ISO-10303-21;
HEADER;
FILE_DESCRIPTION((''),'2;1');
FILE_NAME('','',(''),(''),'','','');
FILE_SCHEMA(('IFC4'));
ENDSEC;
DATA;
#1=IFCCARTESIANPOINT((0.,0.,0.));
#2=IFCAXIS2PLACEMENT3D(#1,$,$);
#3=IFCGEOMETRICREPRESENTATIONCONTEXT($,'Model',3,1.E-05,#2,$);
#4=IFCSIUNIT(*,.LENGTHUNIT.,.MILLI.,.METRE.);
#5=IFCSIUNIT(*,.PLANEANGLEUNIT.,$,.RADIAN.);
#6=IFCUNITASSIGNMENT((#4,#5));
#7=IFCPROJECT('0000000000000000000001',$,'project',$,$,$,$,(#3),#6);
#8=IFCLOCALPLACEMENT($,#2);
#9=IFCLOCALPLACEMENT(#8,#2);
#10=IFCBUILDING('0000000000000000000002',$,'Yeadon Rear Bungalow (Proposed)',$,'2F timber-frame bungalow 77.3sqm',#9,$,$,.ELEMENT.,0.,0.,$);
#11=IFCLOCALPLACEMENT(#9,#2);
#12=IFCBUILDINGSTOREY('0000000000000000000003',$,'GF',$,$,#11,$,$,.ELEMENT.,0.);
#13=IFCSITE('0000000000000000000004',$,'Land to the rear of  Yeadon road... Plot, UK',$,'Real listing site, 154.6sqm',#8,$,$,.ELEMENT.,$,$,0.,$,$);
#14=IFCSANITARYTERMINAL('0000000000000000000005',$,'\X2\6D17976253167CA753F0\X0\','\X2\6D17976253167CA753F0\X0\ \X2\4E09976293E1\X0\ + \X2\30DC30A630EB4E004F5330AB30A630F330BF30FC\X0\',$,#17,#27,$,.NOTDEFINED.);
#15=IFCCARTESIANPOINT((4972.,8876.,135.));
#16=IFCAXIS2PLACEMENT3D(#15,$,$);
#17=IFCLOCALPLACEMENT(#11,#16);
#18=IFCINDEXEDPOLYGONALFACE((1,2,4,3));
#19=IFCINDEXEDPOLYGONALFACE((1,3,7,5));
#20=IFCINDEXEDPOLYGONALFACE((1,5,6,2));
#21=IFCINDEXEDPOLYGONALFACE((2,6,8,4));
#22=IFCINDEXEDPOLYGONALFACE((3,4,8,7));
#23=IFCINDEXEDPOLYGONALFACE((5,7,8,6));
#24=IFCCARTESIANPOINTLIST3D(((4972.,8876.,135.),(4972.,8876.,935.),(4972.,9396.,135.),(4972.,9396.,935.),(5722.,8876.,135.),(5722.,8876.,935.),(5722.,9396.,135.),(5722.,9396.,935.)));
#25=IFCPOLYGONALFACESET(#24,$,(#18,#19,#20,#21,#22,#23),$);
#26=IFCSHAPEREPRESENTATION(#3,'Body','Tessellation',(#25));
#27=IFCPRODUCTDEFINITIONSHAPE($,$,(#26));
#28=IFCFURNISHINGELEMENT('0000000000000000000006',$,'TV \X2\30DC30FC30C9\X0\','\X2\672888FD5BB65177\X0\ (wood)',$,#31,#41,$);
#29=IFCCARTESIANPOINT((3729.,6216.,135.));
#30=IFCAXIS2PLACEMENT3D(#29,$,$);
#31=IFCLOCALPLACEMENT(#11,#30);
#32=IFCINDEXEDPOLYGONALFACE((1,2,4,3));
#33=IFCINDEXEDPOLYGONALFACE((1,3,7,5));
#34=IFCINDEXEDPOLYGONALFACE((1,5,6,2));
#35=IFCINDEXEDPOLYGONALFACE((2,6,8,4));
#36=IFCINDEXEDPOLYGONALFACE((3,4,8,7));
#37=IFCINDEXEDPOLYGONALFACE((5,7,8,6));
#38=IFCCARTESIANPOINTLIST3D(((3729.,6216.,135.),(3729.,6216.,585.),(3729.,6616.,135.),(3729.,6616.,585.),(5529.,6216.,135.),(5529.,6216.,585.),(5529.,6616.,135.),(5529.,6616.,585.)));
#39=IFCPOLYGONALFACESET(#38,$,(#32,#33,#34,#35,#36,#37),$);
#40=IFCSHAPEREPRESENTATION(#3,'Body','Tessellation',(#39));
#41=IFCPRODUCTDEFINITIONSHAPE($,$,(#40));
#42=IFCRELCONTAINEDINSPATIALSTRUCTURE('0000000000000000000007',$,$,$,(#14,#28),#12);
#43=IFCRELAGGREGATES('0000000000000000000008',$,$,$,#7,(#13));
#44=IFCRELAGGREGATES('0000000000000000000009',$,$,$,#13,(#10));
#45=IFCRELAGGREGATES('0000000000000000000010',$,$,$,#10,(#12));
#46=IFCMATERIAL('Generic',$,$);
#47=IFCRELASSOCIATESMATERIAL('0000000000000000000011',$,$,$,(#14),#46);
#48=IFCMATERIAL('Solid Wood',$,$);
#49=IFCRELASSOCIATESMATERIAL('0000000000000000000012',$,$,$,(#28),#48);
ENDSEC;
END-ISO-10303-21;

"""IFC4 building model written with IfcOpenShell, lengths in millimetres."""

from ifc_helpers import new_model, si_unit, frame, frame_2d, origin, place, context, project, spatial, rectangle, extrude, material, element, save


model = new_model("IFC4")

# Units and contexts
model_context = context("Model", 3, precision=1e-05, world=origin())
ifc_project = project(units=[si_unit("LENGTHUNIT", "METRE", prefix="MILLI"), si_unit("PLANEANGLEUNIT", "RADIAN")], contexts=[model_context])

# Site, building, storey
site_placement = place(None, origin())
site = spatial("IfcSite", under=ifc_project, at=site_placement, Name="Land to the rear of  Yeadon road... Plot, UK", ObjectType="Real listing site, 154.6sqm", CompositionType="ELEMENT", RefElevation=0.0)
building_placement = place(site_placement, origin())
building = spatial("IfcBuilding", under=site, at=building_placement, Name="Yeadon Rear Bungalow (Proposed)", ObjectType="2F timber-frame bungalow 77.3sqm", CompositionType="ELEMENT", ElevationOfRefHeight=0.0, ElevationOfTerrain=0.0)
storey_placement = place(building_placement, origin())
storey = spatial("IfcBuildingStorey", under=building, at=storey_placement, Name="GF", CompositionType="ELEMENT", Elevation=0.0)

# Shared definitions
ifc_material_1 = material(Name="Solid Wood")

# Shared definitions
ifc_material_2 = material(Name="Generic")

# Sanitary terminal
sanitary_terminal_1_placement = place(storey_placement, frame((4972.0, 8876.0, 135.0)))
element("IfcSanitaryTerminal", 1, at=sanitary_terminal_1_placement, inside=storey, material=ifc_material_2, Name="洗面化粧台", Description="洗面化粧台 三面鏡 + ボウル一体カウンター", PredefinedType="NOTDEFINED", context=model_context, shape_type="SweptSolid", body=[
    extrude(rectangle(XDim=750.0, YDim=520.0, at=frame_2d((375.0, 260.0))), frame((4972.0, 8876.0, 135.0)), (0.0, 0.0, 1.0), 800.0),
])

# Furnishing element
furnishing_placement = place(storey_placement, frame((3729.0, 6216.0, 135.0)))
element("IfcFurnishingElement", 2, at=furnishing_placement, inside=storey, material=ifc_material_1, Name="TV ボード", Description="木製家具 (wood)", context=model_context, shape_type="SweptSolid", body=[
    extrude(rectangle(XDim=1800.0, YDim=400.0, at=frame_2d((900.0, 200.0))), frame((3729.0, 6216.0, 135.0)), (0.0, 0.0, 1.0), 450.0),
])

save(model, "model.ifc")
